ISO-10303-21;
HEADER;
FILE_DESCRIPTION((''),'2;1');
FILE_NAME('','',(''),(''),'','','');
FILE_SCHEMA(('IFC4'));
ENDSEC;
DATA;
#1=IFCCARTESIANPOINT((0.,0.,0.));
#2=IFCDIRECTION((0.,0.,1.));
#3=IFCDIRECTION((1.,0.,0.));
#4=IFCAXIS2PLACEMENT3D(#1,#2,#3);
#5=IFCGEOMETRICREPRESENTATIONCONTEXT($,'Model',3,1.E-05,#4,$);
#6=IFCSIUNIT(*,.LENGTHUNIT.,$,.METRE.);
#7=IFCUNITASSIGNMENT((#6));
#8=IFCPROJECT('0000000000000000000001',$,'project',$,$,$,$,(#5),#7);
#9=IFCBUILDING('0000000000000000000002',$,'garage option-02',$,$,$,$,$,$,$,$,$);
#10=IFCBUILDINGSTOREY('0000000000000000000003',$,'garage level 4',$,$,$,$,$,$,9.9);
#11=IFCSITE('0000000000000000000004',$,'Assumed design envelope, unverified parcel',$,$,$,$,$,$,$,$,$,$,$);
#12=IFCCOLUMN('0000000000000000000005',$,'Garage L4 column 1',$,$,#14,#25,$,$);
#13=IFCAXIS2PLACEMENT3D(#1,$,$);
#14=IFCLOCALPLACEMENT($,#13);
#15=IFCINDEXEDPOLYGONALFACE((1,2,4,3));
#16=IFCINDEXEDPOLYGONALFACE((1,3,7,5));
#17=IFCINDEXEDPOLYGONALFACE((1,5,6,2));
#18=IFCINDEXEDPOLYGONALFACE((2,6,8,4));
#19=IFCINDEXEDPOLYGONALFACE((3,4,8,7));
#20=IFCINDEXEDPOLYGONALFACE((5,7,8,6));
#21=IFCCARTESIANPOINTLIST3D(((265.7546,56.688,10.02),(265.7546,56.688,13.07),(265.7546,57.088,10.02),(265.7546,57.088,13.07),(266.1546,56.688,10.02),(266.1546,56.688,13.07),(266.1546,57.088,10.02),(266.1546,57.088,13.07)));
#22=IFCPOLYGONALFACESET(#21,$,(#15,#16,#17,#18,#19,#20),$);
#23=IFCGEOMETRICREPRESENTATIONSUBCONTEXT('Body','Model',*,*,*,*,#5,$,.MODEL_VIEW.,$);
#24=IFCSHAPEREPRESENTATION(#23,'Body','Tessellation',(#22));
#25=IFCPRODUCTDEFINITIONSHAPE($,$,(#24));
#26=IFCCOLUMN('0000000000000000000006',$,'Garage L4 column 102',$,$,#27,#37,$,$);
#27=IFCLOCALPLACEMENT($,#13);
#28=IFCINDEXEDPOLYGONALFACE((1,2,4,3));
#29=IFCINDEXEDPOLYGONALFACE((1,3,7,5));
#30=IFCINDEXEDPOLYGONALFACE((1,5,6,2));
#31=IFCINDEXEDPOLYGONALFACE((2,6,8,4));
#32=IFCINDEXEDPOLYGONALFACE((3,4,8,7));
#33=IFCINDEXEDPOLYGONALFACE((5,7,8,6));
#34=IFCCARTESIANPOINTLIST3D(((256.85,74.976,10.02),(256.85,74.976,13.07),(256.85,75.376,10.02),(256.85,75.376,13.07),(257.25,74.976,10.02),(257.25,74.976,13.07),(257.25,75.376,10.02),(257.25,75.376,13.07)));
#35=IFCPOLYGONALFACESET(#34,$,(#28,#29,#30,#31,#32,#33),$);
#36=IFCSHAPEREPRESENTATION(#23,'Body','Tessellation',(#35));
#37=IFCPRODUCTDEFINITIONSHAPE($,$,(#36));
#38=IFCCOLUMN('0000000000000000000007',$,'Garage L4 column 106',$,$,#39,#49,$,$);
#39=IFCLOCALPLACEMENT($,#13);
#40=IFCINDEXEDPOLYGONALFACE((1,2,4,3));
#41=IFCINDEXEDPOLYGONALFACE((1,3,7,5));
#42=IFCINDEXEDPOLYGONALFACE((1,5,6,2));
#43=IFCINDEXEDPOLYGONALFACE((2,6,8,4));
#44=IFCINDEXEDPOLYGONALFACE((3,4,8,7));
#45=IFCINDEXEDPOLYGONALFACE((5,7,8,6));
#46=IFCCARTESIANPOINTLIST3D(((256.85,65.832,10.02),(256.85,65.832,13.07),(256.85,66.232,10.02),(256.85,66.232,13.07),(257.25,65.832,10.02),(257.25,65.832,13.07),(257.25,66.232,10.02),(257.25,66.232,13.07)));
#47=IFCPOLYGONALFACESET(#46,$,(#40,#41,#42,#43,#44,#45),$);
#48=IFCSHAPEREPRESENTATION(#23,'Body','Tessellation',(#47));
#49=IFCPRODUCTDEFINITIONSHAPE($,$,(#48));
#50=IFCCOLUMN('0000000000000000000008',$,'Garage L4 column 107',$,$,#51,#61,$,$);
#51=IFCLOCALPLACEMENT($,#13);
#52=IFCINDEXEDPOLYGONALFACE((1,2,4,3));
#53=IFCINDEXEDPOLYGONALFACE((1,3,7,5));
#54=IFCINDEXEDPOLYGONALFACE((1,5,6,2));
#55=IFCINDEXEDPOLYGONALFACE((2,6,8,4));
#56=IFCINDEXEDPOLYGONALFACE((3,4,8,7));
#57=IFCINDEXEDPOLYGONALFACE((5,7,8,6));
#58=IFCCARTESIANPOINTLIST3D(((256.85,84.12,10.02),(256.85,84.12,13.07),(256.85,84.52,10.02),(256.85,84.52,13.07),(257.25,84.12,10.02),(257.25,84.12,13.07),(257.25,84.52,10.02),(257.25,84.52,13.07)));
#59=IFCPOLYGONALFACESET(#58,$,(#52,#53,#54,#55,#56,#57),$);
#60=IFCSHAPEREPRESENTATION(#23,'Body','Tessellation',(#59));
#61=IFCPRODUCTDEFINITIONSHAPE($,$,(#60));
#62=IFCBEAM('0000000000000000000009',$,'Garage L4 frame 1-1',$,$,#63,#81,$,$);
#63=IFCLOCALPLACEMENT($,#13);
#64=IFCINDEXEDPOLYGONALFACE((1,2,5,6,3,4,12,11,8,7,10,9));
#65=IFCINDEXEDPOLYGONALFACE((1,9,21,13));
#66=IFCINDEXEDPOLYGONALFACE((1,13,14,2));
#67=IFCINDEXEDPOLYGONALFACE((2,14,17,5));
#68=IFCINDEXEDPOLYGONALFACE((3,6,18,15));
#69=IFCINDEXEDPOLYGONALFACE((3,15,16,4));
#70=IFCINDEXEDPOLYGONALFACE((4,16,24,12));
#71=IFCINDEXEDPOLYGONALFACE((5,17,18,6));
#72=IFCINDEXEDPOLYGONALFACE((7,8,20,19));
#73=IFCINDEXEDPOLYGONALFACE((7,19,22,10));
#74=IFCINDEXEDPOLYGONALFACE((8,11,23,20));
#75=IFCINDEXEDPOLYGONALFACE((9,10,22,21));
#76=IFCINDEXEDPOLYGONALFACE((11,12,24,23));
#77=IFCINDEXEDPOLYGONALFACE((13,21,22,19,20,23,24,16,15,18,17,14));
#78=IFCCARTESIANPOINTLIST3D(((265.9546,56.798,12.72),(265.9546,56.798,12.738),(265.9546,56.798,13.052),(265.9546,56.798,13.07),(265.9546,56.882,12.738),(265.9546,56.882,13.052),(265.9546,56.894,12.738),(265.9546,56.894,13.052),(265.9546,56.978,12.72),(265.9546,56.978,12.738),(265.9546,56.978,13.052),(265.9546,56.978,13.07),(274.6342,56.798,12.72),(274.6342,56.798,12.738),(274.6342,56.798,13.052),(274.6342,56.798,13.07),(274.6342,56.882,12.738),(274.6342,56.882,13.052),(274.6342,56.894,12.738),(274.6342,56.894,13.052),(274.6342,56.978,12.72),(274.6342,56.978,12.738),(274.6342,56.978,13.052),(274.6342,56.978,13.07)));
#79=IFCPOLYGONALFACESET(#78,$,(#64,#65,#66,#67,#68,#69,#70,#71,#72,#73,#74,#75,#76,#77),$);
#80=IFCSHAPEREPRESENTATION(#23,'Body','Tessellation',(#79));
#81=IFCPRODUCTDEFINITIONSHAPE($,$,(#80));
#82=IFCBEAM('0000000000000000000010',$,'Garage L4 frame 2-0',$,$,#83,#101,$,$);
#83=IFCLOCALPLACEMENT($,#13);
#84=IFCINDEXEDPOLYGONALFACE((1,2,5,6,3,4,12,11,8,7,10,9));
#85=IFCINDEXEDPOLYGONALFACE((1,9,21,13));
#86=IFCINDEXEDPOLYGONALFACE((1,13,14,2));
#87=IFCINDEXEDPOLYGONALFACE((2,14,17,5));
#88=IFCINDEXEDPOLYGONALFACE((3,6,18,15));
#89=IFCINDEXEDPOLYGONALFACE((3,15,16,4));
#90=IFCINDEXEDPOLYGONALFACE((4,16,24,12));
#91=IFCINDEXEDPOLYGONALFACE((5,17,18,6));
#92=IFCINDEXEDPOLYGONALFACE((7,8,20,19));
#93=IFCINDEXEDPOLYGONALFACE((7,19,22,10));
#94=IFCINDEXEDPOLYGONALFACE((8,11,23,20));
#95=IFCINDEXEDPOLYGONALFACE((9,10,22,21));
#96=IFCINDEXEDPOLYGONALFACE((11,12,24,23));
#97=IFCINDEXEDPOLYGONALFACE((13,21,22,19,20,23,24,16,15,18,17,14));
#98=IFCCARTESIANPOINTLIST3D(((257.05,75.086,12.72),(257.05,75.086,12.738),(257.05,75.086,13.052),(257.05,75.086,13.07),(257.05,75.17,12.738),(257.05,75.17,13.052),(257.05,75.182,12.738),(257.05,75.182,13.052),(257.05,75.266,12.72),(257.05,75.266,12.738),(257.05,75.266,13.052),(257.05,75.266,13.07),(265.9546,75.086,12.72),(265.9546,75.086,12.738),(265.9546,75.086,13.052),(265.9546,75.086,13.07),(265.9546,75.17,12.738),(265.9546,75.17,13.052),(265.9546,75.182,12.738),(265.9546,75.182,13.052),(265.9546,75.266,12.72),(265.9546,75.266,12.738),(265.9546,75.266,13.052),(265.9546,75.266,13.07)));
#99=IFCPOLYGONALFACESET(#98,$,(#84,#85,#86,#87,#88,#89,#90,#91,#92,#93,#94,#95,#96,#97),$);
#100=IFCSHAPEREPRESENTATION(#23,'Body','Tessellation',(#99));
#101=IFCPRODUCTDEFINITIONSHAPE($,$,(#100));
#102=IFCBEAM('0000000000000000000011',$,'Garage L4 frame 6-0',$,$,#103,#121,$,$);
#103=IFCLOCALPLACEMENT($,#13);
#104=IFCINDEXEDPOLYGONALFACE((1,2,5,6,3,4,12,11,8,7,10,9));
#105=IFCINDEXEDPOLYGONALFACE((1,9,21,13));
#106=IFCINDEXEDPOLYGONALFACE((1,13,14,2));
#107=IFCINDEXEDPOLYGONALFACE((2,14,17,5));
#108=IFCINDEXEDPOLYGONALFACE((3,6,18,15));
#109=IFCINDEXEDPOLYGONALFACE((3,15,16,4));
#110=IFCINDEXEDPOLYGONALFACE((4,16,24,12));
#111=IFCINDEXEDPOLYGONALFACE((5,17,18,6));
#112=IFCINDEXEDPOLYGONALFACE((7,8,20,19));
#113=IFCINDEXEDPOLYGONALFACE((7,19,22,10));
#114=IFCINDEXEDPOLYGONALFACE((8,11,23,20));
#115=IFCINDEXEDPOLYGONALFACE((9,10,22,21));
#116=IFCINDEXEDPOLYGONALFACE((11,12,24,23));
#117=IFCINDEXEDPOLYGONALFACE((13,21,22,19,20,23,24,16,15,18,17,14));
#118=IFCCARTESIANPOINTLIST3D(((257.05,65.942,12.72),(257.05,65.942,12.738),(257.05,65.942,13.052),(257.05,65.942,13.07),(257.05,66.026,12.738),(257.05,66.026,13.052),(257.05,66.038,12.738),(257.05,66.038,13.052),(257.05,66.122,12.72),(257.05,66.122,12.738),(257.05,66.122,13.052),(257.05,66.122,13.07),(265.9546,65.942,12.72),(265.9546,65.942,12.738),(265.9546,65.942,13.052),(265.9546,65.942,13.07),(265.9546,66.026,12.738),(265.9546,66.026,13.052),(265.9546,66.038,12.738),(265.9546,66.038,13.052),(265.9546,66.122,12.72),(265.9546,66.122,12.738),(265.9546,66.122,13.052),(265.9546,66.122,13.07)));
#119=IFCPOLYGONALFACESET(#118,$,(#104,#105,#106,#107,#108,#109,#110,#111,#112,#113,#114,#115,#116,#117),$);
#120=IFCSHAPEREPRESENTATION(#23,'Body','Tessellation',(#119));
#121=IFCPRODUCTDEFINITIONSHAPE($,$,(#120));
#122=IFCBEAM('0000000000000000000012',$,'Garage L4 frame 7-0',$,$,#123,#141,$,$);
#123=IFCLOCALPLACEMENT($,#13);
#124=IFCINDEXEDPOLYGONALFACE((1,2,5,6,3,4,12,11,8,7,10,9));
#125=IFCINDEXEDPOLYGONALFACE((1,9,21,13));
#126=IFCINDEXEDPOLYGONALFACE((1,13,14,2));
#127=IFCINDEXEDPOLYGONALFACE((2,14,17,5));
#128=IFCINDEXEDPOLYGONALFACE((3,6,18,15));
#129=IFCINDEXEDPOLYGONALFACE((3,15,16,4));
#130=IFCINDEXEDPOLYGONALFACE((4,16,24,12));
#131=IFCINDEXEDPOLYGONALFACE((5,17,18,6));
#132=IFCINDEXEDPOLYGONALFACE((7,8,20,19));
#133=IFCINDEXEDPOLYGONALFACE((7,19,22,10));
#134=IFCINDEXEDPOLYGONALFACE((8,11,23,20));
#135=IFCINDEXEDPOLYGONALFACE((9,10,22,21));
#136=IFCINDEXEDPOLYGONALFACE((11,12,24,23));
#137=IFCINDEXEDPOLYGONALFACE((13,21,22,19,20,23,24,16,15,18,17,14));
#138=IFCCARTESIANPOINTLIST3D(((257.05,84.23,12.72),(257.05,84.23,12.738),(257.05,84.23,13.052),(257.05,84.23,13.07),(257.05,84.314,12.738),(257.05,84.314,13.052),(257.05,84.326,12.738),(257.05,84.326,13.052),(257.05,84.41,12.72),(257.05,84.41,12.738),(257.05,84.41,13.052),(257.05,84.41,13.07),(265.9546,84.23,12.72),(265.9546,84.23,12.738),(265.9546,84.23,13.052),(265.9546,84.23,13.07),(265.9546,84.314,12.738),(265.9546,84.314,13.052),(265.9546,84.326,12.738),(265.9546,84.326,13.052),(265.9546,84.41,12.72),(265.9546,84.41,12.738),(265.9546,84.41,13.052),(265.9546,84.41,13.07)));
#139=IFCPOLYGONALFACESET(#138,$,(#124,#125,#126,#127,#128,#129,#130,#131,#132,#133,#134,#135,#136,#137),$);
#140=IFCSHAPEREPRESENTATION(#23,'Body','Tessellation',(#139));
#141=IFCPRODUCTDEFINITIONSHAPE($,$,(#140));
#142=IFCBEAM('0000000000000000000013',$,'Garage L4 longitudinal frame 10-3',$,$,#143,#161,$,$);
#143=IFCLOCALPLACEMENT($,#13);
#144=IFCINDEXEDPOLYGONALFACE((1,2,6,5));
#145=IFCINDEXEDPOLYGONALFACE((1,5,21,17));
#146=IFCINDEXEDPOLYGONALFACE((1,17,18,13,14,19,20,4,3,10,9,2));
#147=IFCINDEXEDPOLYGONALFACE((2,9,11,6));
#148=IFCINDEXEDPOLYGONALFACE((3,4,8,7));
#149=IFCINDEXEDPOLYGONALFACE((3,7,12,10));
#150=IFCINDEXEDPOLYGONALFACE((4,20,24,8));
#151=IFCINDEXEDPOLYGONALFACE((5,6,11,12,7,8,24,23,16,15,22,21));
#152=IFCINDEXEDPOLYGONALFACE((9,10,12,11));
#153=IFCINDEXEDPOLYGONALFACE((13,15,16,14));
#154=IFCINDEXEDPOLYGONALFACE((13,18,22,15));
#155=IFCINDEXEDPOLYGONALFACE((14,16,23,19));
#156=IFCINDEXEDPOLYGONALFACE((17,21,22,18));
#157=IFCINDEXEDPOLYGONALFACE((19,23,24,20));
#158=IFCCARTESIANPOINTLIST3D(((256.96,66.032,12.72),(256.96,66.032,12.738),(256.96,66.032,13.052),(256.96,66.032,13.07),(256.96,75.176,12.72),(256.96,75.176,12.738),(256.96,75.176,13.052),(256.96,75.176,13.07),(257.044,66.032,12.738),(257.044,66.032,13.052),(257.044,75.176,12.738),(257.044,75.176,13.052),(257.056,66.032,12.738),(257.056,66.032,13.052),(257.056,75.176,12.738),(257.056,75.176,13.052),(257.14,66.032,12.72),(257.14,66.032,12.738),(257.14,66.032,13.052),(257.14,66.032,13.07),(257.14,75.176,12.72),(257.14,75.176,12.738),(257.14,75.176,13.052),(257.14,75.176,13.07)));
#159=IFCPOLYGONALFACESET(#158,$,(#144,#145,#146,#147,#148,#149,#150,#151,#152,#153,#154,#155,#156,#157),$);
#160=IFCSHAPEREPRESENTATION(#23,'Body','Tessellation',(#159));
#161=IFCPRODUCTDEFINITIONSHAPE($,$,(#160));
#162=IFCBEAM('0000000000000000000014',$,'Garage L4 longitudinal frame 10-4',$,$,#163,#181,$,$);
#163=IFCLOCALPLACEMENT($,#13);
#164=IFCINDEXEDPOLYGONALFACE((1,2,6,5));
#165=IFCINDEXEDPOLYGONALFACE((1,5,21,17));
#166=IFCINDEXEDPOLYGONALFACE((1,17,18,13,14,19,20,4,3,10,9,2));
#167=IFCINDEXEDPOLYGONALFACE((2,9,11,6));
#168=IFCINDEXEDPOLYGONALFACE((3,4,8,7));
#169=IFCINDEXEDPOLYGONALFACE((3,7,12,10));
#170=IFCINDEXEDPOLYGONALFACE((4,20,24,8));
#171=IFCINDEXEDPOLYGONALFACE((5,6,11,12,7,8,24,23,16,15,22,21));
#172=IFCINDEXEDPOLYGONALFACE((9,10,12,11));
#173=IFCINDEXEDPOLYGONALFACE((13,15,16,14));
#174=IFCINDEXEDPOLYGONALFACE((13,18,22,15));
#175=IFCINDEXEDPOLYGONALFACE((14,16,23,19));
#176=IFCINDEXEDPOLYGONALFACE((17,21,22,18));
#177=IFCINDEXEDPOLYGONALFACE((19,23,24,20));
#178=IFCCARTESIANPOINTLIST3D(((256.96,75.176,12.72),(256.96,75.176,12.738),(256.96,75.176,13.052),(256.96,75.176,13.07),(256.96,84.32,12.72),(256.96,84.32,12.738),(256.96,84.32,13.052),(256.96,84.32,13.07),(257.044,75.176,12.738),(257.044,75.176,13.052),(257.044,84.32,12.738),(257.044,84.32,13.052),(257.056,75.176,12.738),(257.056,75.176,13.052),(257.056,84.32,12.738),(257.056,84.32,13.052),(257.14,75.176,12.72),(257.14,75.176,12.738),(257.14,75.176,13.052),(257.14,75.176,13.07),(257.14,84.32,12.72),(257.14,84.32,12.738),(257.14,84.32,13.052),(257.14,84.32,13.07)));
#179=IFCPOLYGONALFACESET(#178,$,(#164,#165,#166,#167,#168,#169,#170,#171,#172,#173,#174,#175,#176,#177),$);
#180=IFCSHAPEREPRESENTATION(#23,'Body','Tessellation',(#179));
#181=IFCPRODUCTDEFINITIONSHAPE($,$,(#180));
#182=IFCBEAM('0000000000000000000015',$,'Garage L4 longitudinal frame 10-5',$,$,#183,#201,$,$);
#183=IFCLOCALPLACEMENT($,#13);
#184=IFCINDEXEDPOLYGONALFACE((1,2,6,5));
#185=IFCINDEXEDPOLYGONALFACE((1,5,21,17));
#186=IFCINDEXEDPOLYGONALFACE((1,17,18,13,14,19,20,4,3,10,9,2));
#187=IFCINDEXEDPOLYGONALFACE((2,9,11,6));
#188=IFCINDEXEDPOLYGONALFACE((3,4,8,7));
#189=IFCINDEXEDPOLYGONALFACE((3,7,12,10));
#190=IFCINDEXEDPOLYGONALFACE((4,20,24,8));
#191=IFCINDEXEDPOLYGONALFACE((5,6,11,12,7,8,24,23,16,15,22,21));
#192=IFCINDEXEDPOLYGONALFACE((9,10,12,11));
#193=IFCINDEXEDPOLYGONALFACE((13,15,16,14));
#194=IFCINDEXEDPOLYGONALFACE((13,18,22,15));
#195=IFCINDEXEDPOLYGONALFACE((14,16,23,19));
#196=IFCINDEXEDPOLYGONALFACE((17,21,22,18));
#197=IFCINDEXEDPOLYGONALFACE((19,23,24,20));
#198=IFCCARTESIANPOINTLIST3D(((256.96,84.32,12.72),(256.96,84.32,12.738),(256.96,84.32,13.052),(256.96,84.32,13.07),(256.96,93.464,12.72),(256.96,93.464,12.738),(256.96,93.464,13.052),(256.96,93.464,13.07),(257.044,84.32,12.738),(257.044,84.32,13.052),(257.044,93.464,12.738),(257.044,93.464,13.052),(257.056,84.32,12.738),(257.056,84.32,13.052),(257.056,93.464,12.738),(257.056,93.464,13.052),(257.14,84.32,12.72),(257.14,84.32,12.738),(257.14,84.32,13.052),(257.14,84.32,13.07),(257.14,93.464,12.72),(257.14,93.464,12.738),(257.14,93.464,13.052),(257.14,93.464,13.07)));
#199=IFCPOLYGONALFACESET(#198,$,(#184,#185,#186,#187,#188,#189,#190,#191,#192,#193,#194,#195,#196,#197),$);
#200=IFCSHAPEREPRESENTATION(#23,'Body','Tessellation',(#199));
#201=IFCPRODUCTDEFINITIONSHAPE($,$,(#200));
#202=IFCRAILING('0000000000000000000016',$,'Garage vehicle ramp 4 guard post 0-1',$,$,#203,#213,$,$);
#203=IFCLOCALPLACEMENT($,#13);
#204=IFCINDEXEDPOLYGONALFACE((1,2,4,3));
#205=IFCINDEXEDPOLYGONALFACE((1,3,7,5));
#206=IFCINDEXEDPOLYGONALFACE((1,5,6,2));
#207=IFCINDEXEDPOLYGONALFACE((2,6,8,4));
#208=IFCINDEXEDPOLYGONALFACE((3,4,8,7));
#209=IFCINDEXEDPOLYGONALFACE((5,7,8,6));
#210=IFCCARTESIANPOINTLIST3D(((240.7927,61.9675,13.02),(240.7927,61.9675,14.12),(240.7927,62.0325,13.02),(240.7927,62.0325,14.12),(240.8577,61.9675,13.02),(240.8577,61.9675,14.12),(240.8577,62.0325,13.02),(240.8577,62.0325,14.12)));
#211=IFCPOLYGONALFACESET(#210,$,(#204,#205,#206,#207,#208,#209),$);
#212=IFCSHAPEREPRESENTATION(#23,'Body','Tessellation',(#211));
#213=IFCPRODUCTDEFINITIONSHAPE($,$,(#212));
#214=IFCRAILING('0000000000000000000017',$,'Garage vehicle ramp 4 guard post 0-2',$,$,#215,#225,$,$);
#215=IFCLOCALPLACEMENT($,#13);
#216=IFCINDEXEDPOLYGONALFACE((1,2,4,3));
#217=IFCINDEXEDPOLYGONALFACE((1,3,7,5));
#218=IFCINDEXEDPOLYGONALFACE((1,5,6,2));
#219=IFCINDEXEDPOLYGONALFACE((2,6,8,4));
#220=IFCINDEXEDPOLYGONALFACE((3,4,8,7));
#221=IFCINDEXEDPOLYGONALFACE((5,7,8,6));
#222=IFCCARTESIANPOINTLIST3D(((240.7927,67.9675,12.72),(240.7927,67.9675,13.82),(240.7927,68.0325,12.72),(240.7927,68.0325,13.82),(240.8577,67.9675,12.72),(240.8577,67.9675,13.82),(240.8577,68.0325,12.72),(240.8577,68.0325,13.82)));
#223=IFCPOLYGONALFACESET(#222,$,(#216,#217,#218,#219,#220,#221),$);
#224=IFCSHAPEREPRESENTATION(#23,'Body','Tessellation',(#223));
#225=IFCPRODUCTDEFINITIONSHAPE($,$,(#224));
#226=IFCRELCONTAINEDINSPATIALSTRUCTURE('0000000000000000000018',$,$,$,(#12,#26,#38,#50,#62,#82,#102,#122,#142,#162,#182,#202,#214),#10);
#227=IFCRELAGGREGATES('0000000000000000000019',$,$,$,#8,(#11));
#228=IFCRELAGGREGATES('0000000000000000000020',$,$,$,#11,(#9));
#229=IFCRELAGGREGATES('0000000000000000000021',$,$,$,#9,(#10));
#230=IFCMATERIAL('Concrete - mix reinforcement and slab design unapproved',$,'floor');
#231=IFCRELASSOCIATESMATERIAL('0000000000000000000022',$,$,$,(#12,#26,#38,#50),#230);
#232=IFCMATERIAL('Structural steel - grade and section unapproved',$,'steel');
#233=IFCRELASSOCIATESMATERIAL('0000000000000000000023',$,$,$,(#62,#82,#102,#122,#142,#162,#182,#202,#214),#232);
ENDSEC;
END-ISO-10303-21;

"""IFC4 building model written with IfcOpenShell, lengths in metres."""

from ifc_helpers import new_model, si_unit, frame, origin_with_axes, place, context, subcontext, project, spatial, rectangle, i_section, extrude, material, element, save


model = new_model("IFC4")

# Units and contexts
model_context = context("Model", 3, precision=1e-05, world=origin_with_axes())
body_context = subcontext(model_context, "Body", "Model", "MODEL_VIEW")
ifc_project = project(units=[si_unit("LENGTHUNIT", "METRE")], contexts=[model_context])

# Site, building, storey
site = spatial("IfcSite", under=ifc_project, Name="Assumed design envelope, unverified parcel")
building = spatial("IfcBuilding", under=site, Name="garage option-02")
storey = spatial("IfcBuildingStorey", under=building, Name="garage level 4", Elevation=9.9)

# Columns
ifc_material_1 = material(Name="Concrete - mix reinforcement and slab design unapproved", Category="floor")
for number, where, z_axis, x_axis, name in (
    (1, (265.9546, 56.888, 10.02), (0.0, 0.0, 1.0), (1.0, 0.0, 0.0), "Garage L4 column 1"),
    (2, (257.05, 75.176, 10.02), (0.0, 0.0, 1.0), (1.0, 0.0, 0.0), "Garage L4 column 102"),
    (3, (257.05, 66.032, 10.02), (0.0, 0.0, 1.0), (1.0, 0.0, 0.0), "Garage L4 column 106"),
    (4, (257.05, 84.32, 10.02), (0.0, 0.0, 1.0), (1.0, 0.0, 0.0), "Garage L4 column 107"),
):
    element("IfcColumn", number, at=place(None, frame(where, z_axis=z_axis, x_axis=x_axis)), inside=storey, material=ifc_material_1, Name=name, context=body_context, shape_type="SweptSolid", body=[
        extrude(rectangle(XDim=0.4, YDim=0.4), origin_with_axes(), (0.0, 0.0, 1.0), 3.05),
    ])

# Beams
ifc_material_2 = material(Name="Structural steel - grade and section unapproved", Category="steel")
beam_1_placement = place(None, frame((265.9546, 56.888, 12.895), z_axis=(1.0, 0.0, 0.0), x_axis=(0.0, 1.0, 0.0)))
element("IfcBeam", 5, at=beam_1_placement, inside=storey, material=ifc_material_2, Name="Garage L4 frame 1-1", context=body_context, shape_type="SweptSolid", body=[
    extrude(i_section(OverallWidth=0.18, OverallDepth=0.35, WebThickness=0.012, FlangeThickness=0.018, FilletRadius=0.0), origin_with_axes(), (0.0, 0.0, 1.0), 8.6796),
])
for number, where, z_axis, x_axis, name in (
    (6, (257.05, 75.176, 12.895), (1.0, 0.0, 0.0), (0.0, 1.0, 0.0), "Garage L4 frame 2-0"),
    (7, (257.05, 66.032, 12.895), (1.0, 0.0, 0.0), (0.0, 1.0, 0.0), "Garage L4 frame 6-0"),
    (8, (257.05, 84.32, 12.895), (1.0, 0.0, 0.0), (0.0, 1.0, 0.0), "Garage L4 frame 7-0"),
):
    element("IfcBeam", number, at=place(None, frame(where, z_axis=z_axis, x_axis=x_axis)), inside=storey, material=ifc_material_2, Name=name, context=body_context, shape_type="SweptSolid", body=[
        extrude(i_section(OverallWidth=0.18, OverallDepth=0.35, WebThickness=0.012, FlangeThickness=0.018, FilletRadius=0.0), origin_with_axes(), (0.0, 0.0, 1.0), 8.9046),
    ])
beam_2_placement = place(None, frame((257.05, 66.032, 12.895), z_axis=(0.0, 1.0, 0.0), x_axis=(-1.0, 0.0, 0.0)))
element("IfcBeam", 9, at=beam_2_placement, inside=storey, material=ifc_material_2, Name="Garage L4 longitudinal frame 10-3", context=body_context, shape_type="SweptSolid", body=[
    extrude(i_section(OverallWidth=0.18, OverallDepth=0.35, WebThickness=0.012, FlangeThickness=0.018, FilletRadius=0.0), origin_with_axes(), (0.0, 0.0, 1.0), 9.144),
])
for number, where, z_axis, x_axis, name in (
    (10, (257.05, 75.176, 12.895), (0.0, 1.0, 0.0), (-1.0, 0.0, 0.0), "Garage L4 longitudinal frame 10-4"),
    (11, (257.05, 84.32, 12.895), (0.0, 1.0, 0.0), (-1.0, 0.0, 0.0), "Garage L4 longitudinal frame 10-5"),
):
    element("IfcBeam", number, at=place(None, frame(where, z_axis=z_axis, x_axis=x_axis)), inside=storey, material=ifc_material_2, Name=name, context=body_context, shape_type="SweptSolid", body=[
        extrude(i_section(OverallWidth=0.18, OverallDepth=0.35, WebThickness=0.012, FlangeThickness=0.018, FilletRadius=0.0), origin_with_axes(), (0.0, 0.0, 1.0), 9.144),
    ])

# Railings
for number, where, z_axis, x_axis, name in (
    (12, (240.8252, 62.0, 13.02), (0.0, 0.0, 1.0), (-1.0, 0.0, 0.0), "Garage vehicle ramp 4 guard post 0-1"),
    (13, (240.8252, 68.0, 12.72), (0.0, 0.0, 1.0), (-1.0, 0.0, 0.0), "Garage vehicle ramp 4 guard post 0-2"),
):
    element("IfcRailing", number, at=place(None, frame(where, z_axis=z_axis, x_axis=x_axis)), inside=storey, material=ifc_material_2, Name=name, context=body_context, shape_type="SweptSolid", body=[
        extrude(rectangle(XDim=0.065, YDim=0.065), origin_with_axes(), (0.0, 0.0, 1.0), 1.1),
    ])

save(model, "model.ifc")
